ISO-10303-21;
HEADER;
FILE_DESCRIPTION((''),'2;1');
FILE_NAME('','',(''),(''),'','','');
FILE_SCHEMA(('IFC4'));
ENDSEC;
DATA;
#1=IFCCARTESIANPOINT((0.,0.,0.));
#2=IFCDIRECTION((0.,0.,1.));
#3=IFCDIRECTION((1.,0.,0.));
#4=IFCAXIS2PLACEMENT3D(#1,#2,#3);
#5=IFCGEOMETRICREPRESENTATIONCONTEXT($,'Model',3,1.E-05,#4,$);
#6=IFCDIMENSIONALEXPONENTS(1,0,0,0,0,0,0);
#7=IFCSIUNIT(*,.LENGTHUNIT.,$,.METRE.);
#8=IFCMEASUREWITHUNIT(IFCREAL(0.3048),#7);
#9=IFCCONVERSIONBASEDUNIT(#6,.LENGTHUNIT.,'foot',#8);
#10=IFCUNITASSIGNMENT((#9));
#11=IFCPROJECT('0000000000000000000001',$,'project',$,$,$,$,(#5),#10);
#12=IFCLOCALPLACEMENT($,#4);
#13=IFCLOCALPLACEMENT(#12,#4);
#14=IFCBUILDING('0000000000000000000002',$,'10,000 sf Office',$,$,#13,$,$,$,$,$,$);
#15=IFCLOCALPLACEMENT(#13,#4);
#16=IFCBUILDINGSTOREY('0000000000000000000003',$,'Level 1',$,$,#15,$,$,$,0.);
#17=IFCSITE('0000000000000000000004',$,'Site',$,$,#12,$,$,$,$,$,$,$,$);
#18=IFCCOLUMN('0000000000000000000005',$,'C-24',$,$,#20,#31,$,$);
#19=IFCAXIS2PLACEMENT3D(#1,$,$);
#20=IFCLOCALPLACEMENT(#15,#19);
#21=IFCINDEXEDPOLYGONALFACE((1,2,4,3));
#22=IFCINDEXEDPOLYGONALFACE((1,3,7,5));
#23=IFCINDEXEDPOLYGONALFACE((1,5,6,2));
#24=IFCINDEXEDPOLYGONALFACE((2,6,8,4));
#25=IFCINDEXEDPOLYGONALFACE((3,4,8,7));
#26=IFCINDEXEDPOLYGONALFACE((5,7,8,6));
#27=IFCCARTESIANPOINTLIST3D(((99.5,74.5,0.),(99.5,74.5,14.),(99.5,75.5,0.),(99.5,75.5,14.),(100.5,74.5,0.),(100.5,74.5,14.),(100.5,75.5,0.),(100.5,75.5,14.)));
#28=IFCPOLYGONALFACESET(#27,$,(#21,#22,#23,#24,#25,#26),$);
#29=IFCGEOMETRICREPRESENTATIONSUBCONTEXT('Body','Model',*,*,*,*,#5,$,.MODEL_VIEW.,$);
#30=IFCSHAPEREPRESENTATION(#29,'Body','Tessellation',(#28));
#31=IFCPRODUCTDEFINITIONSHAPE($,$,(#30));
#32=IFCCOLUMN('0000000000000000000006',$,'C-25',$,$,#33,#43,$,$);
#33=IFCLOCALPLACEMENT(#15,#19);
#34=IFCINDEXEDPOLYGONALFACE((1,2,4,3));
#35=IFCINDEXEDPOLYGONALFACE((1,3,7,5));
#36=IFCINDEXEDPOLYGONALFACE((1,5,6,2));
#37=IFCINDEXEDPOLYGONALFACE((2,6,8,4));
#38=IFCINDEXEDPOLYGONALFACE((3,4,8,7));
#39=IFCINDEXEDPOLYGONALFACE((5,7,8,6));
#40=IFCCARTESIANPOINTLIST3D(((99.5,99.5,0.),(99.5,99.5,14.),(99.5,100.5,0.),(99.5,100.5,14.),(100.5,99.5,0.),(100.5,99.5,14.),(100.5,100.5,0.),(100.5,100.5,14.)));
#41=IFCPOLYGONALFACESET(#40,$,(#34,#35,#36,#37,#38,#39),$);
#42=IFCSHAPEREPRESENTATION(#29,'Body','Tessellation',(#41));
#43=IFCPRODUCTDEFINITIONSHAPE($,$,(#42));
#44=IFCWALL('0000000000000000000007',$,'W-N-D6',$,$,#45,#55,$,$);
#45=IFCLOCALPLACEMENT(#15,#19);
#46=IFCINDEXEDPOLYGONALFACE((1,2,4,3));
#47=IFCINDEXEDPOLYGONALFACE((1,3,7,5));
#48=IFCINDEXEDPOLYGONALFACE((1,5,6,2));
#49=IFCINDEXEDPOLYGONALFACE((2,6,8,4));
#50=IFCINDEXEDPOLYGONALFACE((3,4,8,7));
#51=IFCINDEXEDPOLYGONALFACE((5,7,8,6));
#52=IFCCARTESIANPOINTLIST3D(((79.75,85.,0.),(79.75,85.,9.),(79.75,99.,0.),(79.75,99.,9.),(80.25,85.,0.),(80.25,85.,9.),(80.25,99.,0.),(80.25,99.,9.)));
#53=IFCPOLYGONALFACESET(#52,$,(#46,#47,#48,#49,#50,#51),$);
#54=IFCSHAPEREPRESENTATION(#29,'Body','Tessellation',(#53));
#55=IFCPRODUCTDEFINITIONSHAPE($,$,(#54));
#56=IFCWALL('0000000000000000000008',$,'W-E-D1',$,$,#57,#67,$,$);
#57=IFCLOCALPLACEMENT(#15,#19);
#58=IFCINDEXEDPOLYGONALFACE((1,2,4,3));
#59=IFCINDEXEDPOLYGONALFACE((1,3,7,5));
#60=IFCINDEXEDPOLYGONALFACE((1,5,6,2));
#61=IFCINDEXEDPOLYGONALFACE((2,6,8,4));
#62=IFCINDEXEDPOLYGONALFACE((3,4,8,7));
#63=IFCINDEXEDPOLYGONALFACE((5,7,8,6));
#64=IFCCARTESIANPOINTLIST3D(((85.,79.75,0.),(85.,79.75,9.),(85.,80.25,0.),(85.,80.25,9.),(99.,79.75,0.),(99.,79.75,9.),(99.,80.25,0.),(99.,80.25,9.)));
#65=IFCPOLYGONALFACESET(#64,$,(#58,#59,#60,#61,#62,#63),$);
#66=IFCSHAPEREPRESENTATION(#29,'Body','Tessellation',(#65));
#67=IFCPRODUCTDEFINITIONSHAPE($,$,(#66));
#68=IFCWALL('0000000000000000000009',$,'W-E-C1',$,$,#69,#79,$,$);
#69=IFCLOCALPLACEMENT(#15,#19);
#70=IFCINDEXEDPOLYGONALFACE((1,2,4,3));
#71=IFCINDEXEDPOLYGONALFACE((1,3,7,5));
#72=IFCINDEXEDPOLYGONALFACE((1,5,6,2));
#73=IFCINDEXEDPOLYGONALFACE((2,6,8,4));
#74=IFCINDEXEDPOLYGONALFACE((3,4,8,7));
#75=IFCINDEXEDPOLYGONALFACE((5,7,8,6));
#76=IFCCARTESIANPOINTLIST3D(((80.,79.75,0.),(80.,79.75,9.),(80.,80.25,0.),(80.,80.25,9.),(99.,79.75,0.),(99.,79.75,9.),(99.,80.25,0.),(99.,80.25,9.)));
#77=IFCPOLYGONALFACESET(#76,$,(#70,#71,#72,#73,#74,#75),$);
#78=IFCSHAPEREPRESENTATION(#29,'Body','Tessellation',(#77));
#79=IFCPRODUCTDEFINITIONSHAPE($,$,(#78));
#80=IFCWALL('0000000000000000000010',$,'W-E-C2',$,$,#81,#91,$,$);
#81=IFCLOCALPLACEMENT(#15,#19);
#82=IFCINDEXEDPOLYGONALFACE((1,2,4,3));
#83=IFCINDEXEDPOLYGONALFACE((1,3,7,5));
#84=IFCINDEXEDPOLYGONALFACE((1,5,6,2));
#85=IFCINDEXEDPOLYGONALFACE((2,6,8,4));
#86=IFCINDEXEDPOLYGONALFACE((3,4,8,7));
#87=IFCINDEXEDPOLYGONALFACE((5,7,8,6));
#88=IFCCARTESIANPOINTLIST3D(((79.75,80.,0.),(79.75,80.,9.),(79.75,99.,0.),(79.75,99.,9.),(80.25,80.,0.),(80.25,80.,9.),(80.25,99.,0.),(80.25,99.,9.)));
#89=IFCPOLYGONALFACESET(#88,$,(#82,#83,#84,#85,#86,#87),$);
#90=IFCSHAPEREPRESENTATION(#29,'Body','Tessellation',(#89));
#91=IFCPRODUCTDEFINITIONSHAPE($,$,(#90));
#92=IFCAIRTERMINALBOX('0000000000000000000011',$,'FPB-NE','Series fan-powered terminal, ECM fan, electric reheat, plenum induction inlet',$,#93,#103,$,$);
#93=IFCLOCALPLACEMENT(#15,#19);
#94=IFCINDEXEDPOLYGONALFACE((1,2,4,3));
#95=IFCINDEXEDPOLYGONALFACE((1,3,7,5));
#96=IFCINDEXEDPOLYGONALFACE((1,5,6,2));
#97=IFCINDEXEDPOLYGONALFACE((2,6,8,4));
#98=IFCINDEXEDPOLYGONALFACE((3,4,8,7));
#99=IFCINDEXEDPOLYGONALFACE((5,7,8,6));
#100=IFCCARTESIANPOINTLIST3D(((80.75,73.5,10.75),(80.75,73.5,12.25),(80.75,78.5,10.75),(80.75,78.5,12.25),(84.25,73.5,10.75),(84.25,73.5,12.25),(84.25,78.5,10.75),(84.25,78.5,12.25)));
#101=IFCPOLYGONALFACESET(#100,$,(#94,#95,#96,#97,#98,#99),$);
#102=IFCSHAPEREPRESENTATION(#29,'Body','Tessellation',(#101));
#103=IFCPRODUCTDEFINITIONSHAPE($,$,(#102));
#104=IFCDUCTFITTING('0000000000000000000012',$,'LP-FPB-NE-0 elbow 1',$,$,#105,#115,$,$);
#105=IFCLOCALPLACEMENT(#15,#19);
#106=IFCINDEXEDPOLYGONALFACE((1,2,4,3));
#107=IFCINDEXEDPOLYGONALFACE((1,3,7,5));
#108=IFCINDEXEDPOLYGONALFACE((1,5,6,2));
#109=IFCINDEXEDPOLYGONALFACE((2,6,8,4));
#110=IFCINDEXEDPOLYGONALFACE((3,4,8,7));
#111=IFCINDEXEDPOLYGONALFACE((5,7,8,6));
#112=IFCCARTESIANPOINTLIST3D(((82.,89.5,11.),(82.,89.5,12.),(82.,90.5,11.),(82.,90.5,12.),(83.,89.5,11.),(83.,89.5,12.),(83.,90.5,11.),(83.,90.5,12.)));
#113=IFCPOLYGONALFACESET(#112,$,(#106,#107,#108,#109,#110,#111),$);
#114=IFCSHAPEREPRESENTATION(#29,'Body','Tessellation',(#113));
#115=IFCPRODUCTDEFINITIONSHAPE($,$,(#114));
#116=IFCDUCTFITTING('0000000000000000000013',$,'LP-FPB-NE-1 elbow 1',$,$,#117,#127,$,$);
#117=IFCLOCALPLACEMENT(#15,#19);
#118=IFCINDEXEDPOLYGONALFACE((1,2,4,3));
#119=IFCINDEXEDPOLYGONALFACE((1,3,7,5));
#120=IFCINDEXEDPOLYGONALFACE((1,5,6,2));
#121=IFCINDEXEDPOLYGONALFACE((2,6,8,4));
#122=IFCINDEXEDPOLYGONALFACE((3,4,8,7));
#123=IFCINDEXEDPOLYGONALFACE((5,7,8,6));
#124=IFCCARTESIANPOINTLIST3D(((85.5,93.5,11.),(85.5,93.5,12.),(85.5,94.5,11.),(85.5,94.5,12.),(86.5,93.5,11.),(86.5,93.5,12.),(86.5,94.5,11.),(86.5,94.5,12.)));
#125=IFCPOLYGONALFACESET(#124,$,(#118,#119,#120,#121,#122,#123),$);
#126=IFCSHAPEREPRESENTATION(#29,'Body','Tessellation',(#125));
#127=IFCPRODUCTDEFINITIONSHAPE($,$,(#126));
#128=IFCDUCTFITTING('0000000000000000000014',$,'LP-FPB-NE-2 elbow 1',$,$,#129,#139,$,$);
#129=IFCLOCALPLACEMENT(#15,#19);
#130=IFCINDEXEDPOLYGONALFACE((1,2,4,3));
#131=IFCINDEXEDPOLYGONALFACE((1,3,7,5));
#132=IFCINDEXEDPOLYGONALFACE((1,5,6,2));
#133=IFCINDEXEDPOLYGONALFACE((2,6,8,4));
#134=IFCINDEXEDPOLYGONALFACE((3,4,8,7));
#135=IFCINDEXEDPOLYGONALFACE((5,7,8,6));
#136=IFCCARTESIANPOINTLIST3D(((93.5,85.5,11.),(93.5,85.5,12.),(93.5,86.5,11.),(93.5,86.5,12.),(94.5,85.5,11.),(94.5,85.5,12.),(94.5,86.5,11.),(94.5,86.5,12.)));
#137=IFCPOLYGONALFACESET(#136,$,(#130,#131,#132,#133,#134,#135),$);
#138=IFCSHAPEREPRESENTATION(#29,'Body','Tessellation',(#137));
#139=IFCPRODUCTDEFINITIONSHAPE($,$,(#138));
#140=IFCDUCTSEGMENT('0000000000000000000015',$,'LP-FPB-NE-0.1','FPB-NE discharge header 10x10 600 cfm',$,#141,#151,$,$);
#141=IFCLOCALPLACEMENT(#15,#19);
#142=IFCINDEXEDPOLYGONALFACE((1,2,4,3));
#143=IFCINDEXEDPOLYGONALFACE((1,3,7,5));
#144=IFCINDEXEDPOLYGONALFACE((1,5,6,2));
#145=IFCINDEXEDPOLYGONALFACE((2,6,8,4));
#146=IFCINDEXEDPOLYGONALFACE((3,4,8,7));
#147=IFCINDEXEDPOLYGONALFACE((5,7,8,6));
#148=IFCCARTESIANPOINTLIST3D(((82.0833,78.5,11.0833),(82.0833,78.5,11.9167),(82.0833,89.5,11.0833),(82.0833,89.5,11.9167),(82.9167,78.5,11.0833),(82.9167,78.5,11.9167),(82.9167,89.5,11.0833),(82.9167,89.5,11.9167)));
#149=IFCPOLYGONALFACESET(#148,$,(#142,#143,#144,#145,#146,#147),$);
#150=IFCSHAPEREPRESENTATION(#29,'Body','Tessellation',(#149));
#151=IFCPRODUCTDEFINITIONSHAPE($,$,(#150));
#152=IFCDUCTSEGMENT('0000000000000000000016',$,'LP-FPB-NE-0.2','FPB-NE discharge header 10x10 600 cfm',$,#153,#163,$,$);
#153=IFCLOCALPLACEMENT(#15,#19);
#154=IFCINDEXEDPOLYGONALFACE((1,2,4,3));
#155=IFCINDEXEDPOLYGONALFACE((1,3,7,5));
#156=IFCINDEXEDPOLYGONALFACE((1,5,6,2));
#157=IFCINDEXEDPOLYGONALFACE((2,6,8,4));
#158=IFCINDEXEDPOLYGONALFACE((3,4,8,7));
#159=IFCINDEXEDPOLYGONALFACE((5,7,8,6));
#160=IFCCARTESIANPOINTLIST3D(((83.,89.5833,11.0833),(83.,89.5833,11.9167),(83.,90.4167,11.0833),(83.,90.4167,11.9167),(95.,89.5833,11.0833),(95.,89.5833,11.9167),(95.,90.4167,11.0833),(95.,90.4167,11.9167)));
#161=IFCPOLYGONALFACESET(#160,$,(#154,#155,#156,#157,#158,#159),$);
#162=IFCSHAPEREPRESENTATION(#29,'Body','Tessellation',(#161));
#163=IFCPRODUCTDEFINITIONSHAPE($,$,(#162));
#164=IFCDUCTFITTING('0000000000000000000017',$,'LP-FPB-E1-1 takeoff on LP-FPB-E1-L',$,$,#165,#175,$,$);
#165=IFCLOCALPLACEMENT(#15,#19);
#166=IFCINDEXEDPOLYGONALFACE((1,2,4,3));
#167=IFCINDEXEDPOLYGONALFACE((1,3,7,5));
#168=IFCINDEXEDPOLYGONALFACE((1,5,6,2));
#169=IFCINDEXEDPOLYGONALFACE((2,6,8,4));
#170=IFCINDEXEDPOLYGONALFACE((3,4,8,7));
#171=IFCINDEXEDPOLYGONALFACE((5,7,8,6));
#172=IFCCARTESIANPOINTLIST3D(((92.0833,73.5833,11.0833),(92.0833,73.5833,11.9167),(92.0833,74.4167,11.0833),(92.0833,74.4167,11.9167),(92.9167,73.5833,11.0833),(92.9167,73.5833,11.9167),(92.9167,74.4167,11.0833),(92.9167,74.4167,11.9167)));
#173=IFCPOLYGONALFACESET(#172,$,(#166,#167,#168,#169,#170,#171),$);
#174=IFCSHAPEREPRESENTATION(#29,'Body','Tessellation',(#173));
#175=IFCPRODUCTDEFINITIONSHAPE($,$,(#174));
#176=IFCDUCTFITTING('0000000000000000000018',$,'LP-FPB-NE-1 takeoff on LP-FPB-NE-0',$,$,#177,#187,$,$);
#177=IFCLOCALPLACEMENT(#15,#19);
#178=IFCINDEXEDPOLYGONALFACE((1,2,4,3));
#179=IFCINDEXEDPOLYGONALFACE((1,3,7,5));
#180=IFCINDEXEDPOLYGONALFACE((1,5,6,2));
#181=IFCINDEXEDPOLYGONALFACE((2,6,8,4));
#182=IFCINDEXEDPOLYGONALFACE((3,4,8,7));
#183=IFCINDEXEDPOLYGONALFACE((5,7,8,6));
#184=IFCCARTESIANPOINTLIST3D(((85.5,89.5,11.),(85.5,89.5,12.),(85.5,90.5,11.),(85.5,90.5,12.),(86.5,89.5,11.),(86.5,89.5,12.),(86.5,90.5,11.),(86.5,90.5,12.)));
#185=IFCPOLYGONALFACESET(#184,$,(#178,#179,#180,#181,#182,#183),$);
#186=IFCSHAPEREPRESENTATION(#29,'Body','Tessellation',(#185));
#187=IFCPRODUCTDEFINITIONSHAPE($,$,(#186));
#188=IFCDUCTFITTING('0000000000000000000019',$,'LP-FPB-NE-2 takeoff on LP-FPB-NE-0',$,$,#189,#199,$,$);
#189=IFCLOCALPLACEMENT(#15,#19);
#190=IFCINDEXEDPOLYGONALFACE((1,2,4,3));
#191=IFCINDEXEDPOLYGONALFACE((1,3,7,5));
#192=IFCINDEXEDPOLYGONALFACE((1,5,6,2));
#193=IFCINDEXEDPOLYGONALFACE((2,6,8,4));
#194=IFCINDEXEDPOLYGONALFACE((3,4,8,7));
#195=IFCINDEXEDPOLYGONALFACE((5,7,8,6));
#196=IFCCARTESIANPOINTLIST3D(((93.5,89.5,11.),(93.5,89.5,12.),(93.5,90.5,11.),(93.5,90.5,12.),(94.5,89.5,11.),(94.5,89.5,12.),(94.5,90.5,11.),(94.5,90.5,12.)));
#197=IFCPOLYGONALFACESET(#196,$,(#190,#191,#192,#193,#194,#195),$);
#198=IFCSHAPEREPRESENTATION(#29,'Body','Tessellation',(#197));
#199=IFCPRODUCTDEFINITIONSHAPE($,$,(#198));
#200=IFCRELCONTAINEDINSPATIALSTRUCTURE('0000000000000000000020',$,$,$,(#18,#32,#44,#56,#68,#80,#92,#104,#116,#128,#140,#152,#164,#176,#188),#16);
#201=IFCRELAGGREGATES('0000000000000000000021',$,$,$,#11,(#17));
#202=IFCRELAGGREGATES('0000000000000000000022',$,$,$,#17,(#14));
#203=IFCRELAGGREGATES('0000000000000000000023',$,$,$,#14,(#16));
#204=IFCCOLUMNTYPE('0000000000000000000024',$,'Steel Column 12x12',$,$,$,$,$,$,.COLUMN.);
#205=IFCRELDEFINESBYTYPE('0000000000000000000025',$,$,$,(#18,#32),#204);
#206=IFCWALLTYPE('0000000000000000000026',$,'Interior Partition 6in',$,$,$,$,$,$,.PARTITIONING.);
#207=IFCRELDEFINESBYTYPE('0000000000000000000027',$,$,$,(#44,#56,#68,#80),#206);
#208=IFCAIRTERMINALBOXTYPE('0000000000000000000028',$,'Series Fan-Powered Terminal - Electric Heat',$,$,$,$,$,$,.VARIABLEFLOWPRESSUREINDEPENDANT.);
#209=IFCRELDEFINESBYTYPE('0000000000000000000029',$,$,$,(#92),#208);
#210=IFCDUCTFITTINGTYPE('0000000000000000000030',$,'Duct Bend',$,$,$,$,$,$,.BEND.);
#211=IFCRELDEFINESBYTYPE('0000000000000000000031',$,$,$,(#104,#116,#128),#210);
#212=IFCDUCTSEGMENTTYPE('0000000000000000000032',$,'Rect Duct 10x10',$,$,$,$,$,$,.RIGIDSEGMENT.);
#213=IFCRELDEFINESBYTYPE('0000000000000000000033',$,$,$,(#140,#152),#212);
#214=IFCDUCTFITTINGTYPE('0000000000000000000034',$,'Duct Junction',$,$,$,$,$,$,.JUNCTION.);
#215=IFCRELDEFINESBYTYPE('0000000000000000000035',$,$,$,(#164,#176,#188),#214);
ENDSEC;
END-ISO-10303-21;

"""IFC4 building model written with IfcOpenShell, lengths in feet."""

from ifc_helpers import new_model, entity, si_unit, converted_unit, frame, origin_with_axes, place, context, subcontext, project, spatial, rectangle, extrude, type_object, element, save


model = new_model("IFC4")

# Units and contexts
model_context = context("Model", 3, precision=1e-05, world=origin_with_axes())
body_context = subcontext(model_context, "Body", "Model", "MODEL_VIEW")
ifc_project = project(units=[converted_unit("LENGTHUNIT", "foot", entity("IfcReal", 0.3048), si_unit("LENGTHUNIT", "METRE"), dimensions=[1, 0, 0, 0, 0, 0, 0])], contexts=[model_context])

# Site, building, storey
site_placement = place(None, origin_with_axes())
site = spatial("IfcSite", under=ifc_project, at=site_placement, Name="Site")
building_placement = place(site_placement, origin_with_axes())
building = spatial("IfcBuilding", under=site, at=building_placement, Name="10,000 sf Office")
storey_placement = place(building_placement, origin_with_axes())
storey = spatial("IfcBuildingStorey", under=building, at=storey_placement, Name="Level 1", Elevation=0.0)

# Columns
column_type = type_object("IfcColumnType", Name="Steel Column 12x12", PredefinedType="COLUMN")
for number, where, z_axis, x_axis, name in (
    (1, (100.0, 75.0, 0.0), (0.0, 0.0, 1.0), (1.0, 0.0, 0.0), "C-24"),
    (2, (100.0, 100.0, 0.0), (0.0, 0.0, 1.0), (1.0, 0.0, 0.0), "C-25"),
):
    element("IfcColumn", number, at=place(storey_placement, frame(where, z_axis=z_axis, x_axis=x_axis)), inside=storey, type_object=column_type, Name=name, context=body_context, shape_type="SweptSolid", body=[
        extrude(rectangle(XDim=1.0, YDim=1.0), None, (0.0, 0.0, 1.0), 14.0),
    ])

# Walls
wall_type = type_object("IfcWallType", Name="Interior Partition 6in", PredefinedType="PARTITIONING")
for number, where, z_axis, x_axis, name in (
    (3, (80.0, 92.0, 0.0), (0.0, 0.0, 1.0), (0.0, -1.0, 0.0), "W-N-D6"),
    (4, (92.0, 80.0, 0.0), (0.0, 0.0, 1.0), (-1.0, 0.0, 0.0), "W-E-D1"),
):
    element("IfcWall", number, at=place(storey_placement, frame(where, z_axis=z_axis, x_axis=x_axis)), inside=storey, type_object=wall_type, Name=name, context=body_context, shape_type="SweptSolid", body=[
        extrude(rectangle(XDim=14.0, YDim=0.5), None, (0.0, 0.0, 1.0), 9.0),
    ])
for number, where, z_axis, x_axis, name in (
    (5, (89.5, 80.0, 0.0), (0.0, 0.0, 1.0), (-1.0, 0.0, 0.0), "W-E-C1"),
    (6, (80.0, 89.5, 0.0), (0.0, 0.0, 1.0), (0.0, 1.0, 0.0), "W-E-C2"),
):
    element("IfcWall", number, at=place(storey_placement, frame(where, z_axis=z_axis, x_axis=x_axis)), inside=storey, type_object=wall_type, Name=name, context=body_context, shape_type="SweptSolid", body=[
        extrude(rectangle(XDim=19.0, YDim=0.5), None, (0.0, 0.0, 1.0), 9.0),
    ])

# Air terminal box
air_terminal_box_type = type_object("IfcAirTerminalBoxType", Name="Series Fan-Powered Terminal - Electric Heat", PredefinedType="VARIABLEFLOWPRESSUREINDEPENDANT")
air_terminal_box_placement = place(storey_placement, frame((82.5, 76.0, 10.75), z_axis=(0.0, 0.0, 1.0), x_axis=(0.0, 1.0, 0.0)))
element("IfcAirTerminalBox", 7, at=air_terminal_box_placement, inside=storey, type_object=air_terminal_box_type, Name="FPB-NE", Description="Series fan-powered terminal, ECM fan, electric reheat, plenum induction inlet", context=body_context, shape_type="SweptSolid", body=[
    extrude(rectangle(XDim=5.0, YDim=3.5), None, (0.0, 0.0, 1.0), 1.5),
])

# Duct fittings
duct_fitting_type_1 = type_object("IfcDuctFittingType", Name="Duct Bend", PredefinedType="BEND")
for number, where, z_axis, x_axis, name in (
    (8, (82.5, 90.0, 11.0), (0.0, 0.0, 1.0), (1.0, 0.0, 0.0), "LP-FPB-NE-0 elbow 1"),
    (9, (86.0, 94.0, 11.0), (0.0, 0.0, 1.0), (1.0, 0.0, 0.0), "LP-FPB-NE-1 elbow 1"),
    (10, (94.0, 86.0, 11.0), (0.0, 0.0, 1.0), (1.0, 0.0, 0.0), "LP-FPB-NE-2 elbow 1"),
):
    element("IfcDuctFitting", number, at=place(storey_placement, frame(where, z_axis=z_axis, x_axis=x_axis)), inside=storey, type_object=duct_fitting_type_1, Name=name, context=body_context, shape_type="SweptSolid", body=[
        extrude(rectangle(XDim=1.0, YDim=1.0), None, (0.0, 0.0, 1.0), 1.0),
    ])

# Duct segments
duct_segment_type_1 = type_object("IfcDuctSegmentType", Name="Rect Duct 10x10", PredefinedType="RIGIDSEGMENT")
duct_segment_1_placement = place(storey_placement, frame((82.5, 78.5, 11.5), z_axis=(0.0, 1.0, 0.0), x_axis=(-1.0, 0.0, 0.0)))
element("IfcDuctSegment", 11, at=duct_segment_1_placement, inside=storey, type_object=duct_segment_type_1, Name="LP-FPB-NE-0.1", Description="FPB-NE discharge header 10x10 600 cfm", context=body_context, shape_type="SweptSolid", body=[
    extrude(rectangle(XDim=0.8333, YDim=0.8333), None, (0.0, 0.0, 1.0), 11.0),
])
duct_segment_2_placement = place(storey_placement, frame((83.0, 90.0, 11.5), z_axis=(1.0, 0.0, 0.0), x_axis=(0.0, 1.0, 0.0)))
element("IfcDuctSegment", 12, at=duct_segment_2_placement, inside=storey, type_object=duct_segment_type_1, Name="LP-FPB-NE-0.2", Description="FPB-NE discharge header 10x10 600 cfm", context=body_context, shape_type="SweptSolid", body=[
    extrude(rectangle(XDim=0.8333, YDim=0.8333), None, (0.0, 0.0, 1.0), 12.0),
])

# Duct fittings
duct_fitting_type_2 = type_object("IfcDuctFittingType", Name="Duct Junction", PredefinedType="JUNCTION")
duct_fitting_placement = place(storey_placement, frame((92.5, 74.0, 11.0833), z_axis=(0.0, 0.0, 1.0), x_axis=(1.0, 0.0, 0.0)))
element("IfcDuctFitting", 13, at=duct_fitting_placement, inside=storey, type_object=duct_fitting_type_2, Name="LP-FPB-E1-1 takeoff on LP-FPB-E1-L", context=body_context, shape_type="SweptSolid", body=[
    extrude(rectangle(XDim=0.8333, YDim=0.8333), None, (0.0, 0.0, 1.0), 0.8333),
])
for number, where, z_axis, x_axis, name in (
    (14, (86.0, 90.0, 11.0), (0.0, 0.0, 1.0), (1.0, 0.0, 0.0), "LP-FPB-NE-1 takeoff on LP-FPB-NE-0"),
    (15, (94.0, 90.0, 11.0), (0.0, 0.0, 1.0), (1.0, 0.0, 0.0), "LP-FPB-NE-2 takeoff on LP-FPB-NE-0"),
):
    element("IfcDuctFitting", number, at=place(storey_placement, frame(where, z_axis=z_axis, x_axis=x_axis)), inside=storey, type_object=duct_fitting_type_2, Name=name, context=body_context, shape_type="SweptSolid", body=[
        extrude(rectangle(XDim=1.0, YDim=1.0), None, (0.0, 0.0, 1.0), 1.0),
    ])

save(model, "model.ifc")
